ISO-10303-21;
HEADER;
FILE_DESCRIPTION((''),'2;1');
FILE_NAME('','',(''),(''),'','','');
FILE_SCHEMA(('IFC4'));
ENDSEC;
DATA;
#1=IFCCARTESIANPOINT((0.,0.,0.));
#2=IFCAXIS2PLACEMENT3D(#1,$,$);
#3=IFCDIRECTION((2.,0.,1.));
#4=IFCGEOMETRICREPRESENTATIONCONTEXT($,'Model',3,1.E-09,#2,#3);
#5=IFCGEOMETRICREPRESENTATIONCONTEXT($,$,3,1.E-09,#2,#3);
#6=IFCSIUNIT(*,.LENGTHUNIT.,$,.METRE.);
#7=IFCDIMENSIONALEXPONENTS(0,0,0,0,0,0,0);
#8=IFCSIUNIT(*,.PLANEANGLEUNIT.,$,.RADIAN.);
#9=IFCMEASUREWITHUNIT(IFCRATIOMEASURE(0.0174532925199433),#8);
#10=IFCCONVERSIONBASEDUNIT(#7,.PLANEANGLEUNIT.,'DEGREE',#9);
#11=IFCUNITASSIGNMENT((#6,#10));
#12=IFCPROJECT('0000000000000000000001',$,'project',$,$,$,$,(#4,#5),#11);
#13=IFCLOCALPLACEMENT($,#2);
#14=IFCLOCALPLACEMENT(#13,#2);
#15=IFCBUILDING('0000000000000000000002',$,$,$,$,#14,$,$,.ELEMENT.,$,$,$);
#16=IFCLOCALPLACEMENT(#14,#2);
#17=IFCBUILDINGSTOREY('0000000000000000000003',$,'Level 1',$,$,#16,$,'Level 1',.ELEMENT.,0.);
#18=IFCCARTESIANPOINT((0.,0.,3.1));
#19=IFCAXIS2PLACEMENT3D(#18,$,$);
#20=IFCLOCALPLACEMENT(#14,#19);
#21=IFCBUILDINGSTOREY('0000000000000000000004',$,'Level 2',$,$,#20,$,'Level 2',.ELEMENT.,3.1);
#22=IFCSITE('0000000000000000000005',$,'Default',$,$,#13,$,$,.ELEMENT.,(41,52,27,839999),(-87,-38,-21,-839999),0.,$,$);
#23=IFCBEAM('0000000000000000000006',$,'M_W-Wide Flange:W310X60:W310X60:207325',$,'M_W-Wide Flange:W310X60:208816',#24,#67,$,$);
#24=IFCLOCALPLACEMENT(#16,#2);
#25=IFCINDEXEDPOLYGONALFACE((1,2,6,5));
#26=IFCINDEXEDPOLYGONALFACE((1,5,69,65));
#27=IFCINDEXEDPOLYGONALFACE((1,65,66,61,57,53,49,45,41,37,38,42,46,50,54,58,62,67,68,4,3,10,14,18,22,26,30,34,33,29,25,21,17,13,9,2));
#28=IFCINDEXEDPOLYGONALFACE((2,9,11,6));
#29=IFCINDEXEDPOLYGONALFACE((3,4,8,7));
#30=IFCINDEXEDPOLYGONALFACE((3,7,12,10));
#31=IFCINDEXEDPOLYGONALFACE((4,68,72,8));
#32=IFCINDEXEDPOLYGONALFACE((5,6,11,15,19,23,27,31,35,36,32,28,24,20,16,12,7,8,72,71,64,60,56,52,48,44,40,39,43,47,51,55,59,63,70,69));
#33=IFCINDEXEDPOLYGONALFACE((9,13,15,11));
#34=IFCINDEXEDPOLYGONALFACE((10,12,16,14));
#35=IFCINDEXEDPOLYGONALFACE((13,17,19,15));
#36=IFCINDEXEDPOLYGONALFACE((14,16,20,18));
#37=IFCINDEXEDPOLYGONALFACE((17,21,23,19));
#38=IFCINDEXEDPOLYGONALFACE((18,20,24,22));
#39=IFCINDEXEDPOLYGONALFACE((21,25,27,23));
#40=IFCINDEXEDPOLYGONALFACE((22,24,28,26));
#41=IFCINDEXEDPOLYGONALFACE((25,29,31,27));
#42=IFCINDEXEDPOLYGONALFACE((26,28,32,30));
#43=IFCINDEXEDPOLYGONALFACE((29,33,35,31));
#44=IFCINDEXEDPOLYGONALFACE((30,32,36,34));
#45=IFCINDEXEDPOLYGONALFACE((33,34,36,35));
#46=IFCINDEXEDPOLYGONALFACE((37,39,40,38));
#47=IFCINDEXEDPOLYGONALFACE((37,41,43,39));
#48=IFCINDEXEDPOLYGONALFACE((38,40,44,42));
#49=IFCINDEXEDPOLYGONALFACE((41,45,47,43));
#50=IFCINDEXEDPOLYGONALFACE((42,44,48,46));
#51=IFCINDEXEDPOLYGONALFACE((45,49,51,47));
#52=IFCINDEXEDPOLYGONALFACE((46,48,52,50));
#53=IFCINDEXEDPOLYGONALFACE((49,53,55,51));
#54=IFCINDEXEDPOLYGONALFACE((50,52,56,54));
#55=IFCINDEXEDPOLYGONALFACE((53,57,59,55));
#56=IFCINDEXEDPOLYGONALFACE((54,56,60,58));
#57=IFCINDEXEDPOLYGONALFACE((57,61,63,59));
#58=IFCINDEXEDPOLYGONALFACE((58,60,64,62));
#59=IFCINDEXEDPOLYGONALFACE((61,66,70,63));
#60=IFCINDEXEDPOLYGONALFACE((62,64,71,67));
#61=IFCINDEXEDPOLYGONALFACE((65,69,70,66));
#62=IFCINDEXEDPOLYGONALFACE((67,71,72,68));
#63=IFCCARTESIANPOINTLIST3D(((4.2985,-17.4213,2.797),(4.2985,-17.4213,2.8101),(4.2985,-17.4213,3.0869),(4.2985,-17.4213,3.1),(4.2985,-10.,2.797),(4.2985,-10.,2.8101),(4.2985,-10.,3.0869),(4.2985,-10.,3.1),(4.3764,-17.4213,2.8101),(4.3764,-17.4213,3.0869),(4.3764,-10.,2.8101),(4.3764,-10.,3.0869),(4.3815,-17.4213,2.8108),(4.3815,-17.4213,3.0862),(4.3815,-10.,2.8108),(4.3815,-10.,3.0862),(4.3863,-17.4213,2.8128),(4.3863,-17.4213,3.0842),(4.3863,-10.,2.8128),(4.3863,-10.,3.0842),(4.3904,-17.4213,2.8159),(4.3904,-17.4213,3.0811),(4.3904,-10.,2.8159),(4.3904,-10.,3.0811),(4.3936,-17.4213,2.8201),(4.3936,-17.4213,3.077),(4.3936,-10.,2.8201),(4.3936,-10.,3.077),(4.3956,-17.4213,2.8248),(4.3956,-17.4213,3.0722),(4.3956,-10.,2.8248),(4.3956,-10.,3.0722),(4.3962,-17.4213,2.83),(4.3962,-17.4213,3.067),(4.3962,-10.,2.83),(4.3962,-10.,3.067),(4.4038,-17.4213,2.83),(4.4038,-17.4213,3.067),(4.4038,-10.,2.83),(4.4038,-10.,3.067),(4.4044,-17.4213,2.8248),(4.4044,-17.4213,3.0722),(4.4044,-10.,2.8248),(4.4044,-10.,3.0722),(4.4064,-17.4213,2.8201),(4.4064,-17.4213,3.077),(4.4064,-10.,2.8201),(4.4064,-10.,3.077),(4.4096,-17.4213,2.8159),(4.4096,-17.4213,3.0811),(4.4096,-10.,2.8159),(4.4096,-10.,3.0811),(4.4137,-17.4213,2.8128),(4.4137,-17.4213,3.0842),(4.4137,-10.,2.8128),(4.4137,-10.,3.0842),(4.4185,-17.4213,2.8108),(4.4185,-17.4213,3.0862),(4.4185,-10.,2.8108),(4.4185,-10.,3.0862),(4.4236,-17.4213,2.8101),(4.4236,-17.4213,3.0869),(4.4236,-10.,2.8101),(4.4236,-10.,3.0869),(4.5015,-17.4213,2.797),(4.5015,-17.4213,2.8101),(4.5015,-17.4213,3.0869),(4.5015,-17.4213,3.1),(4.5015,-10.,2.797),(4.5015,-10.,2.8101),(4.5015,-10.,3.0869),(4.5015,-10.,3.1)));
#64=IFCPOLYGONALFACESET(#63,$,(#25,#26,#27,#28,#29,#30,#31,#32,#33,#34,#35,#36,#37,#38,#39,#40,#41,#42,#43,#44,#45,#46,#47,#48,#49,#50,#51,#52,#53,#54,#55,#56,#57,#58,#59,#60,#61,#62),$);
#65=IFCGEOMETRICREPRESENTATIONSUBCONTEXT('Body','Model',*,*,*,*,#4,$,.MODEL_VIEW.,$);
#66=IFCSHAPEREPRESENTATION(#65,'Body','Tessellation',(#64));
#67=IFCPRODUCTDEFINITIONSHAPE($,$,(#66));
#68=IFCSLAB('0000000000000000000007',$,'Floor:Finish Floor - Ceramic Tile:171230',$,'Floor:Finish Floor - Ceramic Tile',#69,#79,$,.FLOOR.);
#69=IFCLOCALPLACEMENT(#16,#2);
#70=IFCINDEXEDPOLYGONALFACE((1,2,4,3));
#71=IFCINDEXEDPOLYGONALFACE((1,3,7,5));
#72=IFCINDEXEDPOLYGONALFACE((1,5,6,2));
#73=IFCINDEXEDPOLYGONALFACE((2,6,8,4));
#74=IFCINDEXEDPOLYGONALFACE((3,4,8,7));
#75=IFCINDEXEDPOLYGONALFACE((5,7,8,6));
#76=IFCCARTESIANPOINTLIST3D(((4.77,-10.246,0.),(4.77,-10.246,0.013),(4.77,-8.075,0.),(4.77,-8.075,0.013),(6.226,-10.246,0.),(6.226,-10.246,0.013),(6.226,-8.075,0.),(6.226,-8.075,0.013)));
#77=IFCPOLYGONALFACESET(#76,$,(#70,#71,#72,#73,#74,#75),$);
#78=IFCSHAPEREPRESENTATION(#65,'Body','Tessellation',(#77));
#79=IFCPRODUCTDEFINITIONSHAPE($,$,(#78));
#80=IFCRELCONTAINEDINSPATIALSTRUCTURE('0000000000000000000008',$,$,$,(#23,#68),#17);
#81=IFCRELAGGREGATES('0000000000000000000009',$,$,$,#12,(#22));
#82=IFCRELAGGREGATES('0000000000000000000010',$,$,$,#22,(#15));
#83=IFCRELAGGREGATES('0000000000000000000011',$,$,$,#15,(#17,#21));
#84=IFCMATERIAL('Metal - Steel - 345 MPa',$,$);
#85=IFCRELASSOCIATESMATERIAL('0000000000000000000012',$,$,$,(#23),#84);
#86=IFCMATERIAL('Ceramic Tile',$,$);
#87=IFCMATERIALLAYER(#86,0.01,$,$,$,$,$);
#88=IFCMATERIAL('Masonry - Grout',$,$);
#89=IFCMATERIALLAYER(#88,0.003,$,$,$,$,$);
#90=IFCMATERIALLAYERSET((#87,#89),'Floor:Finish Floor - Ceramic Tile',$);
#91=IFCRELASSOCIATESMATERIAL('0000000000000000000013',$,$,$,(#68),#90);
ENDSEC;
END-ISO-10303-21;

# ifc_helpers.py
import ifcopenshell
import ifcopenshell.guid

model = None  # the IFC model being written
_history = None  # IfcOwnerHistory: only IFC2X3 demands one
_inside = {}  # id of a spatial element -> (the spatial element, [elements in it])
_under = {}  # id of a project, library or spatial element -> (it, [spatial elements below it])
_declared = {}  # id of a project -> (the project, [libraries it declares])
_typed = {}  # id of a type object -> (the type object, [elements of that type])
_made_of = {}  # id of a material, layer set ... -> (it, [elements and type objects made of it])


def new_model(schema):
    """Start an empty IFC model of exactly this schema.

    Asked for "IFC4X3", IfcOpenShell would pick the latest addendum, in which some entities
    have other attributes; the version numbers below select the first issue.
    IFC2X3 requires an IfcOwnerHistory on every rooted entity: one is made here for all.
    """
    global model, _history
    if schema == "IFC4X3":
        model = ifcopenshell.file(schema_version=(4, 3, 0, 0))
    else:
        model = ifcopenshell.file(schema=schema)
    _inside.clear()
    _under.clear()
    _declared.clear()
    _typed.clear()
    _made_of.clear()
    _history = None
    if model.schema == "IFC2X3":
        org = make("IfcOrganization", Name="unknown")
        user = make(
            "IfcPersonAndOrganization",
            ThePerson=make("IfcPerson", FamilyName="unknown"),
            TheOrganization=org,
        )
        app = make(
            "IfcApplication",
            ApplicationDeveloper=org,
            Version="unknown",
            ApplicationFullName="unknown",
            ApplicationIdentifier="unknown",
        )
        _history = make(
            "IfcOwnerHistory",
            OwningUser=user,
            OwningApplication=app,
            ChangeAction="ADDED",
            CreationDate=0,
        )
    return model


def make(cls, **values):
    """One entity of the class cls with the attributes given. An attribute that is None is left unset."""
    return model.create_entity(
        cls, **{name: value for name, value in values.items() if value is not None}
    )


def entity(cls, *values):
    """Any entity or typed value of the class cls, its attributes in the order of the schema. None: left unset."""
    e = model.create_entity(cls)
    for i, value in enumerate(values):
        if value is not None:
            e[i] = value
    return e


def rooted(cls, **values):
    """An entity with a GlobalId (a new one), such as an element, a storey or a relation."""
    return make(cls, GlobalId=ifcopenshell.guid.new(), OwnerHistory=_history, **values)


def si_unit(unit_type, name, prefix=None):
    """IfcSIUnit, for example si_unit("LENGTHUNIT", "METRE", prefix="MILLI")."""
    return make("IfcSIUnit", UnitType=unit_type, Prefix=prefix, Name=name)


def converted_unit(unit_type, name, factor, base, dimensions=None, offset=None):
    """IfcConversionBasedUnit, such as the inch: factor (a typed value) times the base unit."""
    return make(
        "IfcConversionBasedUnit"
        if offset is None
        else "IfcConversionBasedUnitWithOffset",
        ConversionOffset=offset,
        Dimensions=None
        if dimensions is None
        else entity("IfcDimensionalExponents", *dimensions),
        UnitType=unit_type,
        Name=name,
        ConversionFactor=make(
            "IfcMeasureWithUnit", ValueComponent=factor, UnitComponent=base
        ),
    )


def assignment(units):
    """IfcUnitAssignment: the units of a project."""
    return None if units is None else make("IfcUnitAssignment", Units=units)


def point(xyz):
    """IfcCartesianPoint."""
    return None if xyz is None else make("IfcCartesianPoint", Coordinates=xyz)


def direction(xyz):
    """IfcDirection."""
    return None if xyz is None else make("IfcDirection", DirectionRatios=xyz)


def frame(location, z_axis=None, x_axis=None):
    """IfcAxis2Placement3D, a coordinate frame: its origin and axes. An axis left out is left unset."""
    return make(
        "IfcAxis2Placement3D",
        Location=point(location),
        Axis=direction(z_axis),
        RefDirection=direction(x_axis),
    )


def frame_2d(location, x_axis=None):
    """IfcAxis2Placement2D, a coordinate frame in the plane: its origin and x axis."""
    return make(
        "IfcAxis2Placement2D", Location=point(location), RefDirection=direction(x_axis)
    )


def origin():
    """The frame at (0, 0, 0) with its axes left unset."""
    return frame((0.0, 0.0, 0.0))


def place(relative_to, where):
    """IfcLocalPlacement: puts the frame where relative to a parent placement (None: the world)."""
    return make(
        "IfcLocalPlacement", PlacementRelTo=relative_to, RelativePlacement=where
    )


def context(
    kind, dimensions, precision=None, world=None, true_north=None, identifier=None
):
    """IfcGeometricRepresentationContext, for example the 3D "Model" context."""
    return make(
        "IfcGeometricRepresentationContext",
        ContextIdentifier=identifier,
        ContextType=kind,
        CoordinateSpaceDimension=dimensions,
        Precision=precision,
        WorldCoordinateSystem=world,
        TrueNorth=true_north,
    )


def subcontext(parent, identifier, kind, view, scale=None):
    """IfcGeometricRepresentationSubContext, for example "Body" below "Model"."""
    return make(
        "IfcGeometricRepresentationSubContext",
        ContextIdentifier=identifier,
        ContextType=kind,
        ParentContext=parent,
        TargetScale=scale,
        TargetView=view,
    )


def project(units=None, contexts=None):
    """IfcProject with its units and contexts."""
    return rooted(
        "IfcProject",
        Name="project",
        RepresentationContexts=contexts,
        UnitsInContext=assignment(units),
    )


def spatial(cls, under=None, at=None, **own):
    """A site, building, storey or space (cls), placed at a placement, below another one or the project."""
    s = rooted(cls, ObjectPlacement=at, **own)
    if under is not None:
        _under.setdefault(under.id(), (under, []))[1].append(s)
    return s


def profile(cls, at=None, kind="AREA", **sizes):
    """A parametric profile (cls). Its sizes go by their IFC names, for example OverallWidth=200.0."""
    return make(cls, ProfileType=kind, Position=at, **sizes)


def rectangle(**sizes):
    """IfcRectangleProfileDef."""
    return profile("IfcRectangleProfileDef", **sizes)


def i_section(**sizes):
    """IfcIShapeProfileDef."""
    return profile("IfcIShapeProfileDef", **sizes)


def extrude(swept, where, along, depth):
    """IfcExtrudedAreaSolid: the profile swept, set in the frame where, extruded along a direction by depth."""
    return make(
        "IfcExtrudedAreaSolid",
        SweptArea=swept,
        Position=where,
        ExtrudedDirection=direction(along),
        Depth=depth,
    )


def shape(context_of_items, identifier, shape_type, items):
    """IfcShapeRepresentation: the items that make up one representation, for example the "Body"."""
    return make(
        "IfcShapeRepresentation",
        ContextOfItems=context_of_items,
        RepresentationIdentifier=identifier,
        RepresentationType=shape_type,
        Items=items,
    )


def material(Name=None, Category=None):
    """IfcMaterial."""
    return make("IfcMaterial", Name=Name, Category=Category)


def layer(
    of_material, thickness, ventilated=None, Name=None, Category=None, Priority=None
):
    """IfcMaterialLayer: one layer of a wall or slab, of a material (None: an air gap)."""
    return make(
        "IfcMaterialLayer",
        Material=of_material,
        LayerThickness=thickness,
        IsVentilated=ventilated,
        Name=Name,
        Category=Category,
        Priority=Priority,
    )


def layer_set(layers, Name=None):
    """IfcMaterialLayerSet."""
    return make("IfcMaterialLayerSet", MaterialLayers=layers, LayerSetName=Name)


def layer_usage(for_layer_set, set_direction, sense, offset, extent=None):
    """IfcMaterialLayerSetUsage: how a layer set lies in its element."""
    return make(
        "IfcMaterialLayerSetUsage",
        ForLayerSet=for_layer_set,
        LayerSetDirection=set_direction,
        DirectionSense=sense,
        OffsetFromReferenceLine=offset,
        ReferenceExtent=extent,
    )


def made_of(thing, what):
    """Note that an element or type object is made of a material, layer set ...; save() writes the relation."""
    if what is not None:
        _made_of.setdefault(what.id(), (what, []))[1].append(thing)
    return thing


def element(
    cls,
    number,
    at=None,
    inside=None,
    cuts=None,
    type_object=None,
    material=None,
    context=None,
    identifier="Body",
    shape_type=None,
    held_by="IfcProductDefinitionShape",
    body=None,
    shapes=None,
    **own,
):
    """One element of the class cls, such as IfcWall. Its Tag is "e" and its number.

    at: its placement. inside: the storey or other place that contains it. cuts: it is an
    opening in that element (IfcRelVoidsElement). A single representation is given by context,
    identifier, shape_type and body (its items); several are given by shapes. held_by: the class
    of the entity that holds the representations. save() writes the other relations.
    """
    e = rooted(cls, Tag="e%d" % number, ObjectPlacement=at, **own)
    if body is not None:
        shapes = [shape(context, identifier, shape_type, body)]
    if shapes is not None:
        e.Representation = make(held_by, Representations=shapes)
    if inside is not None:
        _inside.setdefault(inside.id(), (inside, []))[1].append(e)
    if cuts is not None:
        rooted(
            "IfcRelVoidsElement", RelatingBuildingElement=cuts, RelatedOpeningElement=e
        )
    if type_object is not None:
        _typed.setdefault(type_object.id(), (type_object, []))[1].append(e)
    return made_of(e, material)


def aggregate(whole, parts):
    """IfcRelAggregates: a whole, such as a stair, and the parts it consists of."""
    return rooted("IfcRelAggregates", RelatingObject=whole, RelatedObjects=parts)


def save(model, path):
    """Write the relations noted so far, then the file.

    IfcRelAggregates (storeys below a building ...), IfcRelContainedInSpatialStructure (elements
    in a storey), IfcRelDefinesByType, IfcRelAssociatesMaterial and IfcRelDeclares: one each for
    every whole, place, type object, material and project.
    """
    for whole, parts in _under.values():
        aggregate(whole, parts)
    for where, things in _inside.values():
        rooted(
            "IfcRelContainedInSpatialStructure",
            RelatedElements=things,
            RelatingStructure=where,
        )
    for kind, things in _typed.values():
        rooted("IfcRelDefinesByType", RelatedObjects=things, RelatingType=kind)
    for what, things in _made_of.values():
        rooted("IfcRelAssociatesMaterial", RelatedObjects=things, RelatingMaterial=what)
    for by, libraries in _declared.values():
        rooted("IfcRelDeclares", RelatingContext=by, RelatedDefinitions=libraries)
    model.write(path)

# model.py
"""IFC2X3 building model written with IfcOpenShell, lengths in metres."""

from ifc_helpers import new_model, entity, si_unit, converted_unit, direction, frame, frame_2d, origin, place, context, subcontext, project, spatial, rectangle, i_section, extrude, material, layer, layer_set, layer_usage, element, save


model = new_model("IFC2X3")

# Units and contexts
model_context = context("Model", 3, precision=1e-09, world=origin(), true_north=direction((2.0, 0.0, 1.0)))
context_of_model = context(None, 3, precision=1e-09, world=origin(), true_north=direction((2.0, 0.0, 1.0)))
body_context = subcontext(model_context, "Body", "Model", "MODEL_VIEW")
ifc_project = project(units=[si_unit("LENGTHUNIT", "METRE"), converted_unit("PLANEANGLEUNIT", "DEGREE", entity("IfcRatioMeasure", 0.0174532925199433), si_unit("PLANEANGLEUNIT", "RADIAN"), dimensions=[0, 0, 0, 0, 0, 0, 0])], contexts=[model_context, context_of_model])

# Site, building, storey
site_placement = place(None, origin())
site = spatial("IfcSite", under=ifc_project, at=site_placement, Name="Default", CompositionType="ELEMENT", RefLatitude=(41, 52, 27, 839999), RefLongitude=(-87, -38, -21, -839999), RefElevation=0.0)
building_placement = place(site_placement, origin())
building = spatial("IfcBuilding", under=site, at=building_placement, CompositionType="ELEMENT")
storey_1_placement = place(building_placement, origin())
storey_1 = spatial("IfcBuildingStorey", under=building, at=storey_1_placement, Name="Level 1", LongName="Level 1", CompositionType="ELEMENT", Elevation=0.0)

# Beam
ifc_material_1 = material(Name="Metal - Steel - 345 MPa")
beam_placement = place(storey_1_placement, frame((4.4, -10.0, 3.1), z_axis=(0.0, 0.0, 1.0), x_axis=(0.0, -1.0, 0.0)))
element("IfcBeam", 1, at=beam_placement, inside=storey_1, material=ifc_material_1, Name="M_W-Wide Flange:W310X60:W310X60:207325", ObjectType="M_W-Wide Flange:W310X60:208816", context=body_context, shape_type="SweptSolid", body=[
    extrude(i_section(OverallWidth=0.203, OverallDepth=0.303, WebThickness=0.0075, FlangeThickness=0.0131, FilletRadius=0.0199, at=frame_2d((0.0, 0.0), x_axis=(1.0, 0.0))), frame((0.0, 0.0, -0.1515), z_axis=(-1.0, 0.0, 0.0), x_axis=(0.0, -1.0, 0.0)), (0.0, 0.0, -1.0), 7.4213),
])

# Slab
ifc_material_2 = material(Name="Ceramic Tile")
ifc_layer_1 = layer(ifc_material_2, 0.01)
ifc_material_3 = material(Name="Masonry - Grout")
ifc_layer_2 = layer(ifc_material_3, 0.003)
ifc_layer_set_1 = layer_set([ifc_layer_1, ifc_layer_2], Name="Floor:Finish Floor - Ceramic Tile")
ifc_layer_usage_1 = layer_usage(ifc_layer_set_1, "AXIS3", "POSITIVE", 0.0)
slab_placement = place(storey_1_placement, frame((4.77, -10.246, 0.0)))
element("IfcSlab", 2, at=slab_placement, inside=storey_1, material=ifc_layer_usage_1, Name="Floor:Finish Floor - Ceramic Tile:171230", ObjectType="Floor:Finish Floor - Ceramic Tile", PredefinedType="FLOOR", context=body_context, shape_type="SweptSolid", body=[
    extrude(rectangle(XDim=1.456, YDim=2.171, at=frame_2d((0.0, 0.0), x_axis=(-1.0, 0.0))), frame((0.728, 1.0855, 0.013), z_axis=(0.0, 0.0, -1.0), x_axis=(-1.0, 0.0, 0.0)), (0.0, 0.0, 1.0), 0.013),
])

# Shared definitions
storey_2_placement = place(building_placement, frame((0.0, 0.0, 3.1)))
storey_2 = spatial("IfcBuildingStorey", under=building, at=storey_2_placement, Name="Level 2", LongName="Level 2", CompositionType="ELEMENT", Elevation=3.1)

save(model, "model.ifc")
